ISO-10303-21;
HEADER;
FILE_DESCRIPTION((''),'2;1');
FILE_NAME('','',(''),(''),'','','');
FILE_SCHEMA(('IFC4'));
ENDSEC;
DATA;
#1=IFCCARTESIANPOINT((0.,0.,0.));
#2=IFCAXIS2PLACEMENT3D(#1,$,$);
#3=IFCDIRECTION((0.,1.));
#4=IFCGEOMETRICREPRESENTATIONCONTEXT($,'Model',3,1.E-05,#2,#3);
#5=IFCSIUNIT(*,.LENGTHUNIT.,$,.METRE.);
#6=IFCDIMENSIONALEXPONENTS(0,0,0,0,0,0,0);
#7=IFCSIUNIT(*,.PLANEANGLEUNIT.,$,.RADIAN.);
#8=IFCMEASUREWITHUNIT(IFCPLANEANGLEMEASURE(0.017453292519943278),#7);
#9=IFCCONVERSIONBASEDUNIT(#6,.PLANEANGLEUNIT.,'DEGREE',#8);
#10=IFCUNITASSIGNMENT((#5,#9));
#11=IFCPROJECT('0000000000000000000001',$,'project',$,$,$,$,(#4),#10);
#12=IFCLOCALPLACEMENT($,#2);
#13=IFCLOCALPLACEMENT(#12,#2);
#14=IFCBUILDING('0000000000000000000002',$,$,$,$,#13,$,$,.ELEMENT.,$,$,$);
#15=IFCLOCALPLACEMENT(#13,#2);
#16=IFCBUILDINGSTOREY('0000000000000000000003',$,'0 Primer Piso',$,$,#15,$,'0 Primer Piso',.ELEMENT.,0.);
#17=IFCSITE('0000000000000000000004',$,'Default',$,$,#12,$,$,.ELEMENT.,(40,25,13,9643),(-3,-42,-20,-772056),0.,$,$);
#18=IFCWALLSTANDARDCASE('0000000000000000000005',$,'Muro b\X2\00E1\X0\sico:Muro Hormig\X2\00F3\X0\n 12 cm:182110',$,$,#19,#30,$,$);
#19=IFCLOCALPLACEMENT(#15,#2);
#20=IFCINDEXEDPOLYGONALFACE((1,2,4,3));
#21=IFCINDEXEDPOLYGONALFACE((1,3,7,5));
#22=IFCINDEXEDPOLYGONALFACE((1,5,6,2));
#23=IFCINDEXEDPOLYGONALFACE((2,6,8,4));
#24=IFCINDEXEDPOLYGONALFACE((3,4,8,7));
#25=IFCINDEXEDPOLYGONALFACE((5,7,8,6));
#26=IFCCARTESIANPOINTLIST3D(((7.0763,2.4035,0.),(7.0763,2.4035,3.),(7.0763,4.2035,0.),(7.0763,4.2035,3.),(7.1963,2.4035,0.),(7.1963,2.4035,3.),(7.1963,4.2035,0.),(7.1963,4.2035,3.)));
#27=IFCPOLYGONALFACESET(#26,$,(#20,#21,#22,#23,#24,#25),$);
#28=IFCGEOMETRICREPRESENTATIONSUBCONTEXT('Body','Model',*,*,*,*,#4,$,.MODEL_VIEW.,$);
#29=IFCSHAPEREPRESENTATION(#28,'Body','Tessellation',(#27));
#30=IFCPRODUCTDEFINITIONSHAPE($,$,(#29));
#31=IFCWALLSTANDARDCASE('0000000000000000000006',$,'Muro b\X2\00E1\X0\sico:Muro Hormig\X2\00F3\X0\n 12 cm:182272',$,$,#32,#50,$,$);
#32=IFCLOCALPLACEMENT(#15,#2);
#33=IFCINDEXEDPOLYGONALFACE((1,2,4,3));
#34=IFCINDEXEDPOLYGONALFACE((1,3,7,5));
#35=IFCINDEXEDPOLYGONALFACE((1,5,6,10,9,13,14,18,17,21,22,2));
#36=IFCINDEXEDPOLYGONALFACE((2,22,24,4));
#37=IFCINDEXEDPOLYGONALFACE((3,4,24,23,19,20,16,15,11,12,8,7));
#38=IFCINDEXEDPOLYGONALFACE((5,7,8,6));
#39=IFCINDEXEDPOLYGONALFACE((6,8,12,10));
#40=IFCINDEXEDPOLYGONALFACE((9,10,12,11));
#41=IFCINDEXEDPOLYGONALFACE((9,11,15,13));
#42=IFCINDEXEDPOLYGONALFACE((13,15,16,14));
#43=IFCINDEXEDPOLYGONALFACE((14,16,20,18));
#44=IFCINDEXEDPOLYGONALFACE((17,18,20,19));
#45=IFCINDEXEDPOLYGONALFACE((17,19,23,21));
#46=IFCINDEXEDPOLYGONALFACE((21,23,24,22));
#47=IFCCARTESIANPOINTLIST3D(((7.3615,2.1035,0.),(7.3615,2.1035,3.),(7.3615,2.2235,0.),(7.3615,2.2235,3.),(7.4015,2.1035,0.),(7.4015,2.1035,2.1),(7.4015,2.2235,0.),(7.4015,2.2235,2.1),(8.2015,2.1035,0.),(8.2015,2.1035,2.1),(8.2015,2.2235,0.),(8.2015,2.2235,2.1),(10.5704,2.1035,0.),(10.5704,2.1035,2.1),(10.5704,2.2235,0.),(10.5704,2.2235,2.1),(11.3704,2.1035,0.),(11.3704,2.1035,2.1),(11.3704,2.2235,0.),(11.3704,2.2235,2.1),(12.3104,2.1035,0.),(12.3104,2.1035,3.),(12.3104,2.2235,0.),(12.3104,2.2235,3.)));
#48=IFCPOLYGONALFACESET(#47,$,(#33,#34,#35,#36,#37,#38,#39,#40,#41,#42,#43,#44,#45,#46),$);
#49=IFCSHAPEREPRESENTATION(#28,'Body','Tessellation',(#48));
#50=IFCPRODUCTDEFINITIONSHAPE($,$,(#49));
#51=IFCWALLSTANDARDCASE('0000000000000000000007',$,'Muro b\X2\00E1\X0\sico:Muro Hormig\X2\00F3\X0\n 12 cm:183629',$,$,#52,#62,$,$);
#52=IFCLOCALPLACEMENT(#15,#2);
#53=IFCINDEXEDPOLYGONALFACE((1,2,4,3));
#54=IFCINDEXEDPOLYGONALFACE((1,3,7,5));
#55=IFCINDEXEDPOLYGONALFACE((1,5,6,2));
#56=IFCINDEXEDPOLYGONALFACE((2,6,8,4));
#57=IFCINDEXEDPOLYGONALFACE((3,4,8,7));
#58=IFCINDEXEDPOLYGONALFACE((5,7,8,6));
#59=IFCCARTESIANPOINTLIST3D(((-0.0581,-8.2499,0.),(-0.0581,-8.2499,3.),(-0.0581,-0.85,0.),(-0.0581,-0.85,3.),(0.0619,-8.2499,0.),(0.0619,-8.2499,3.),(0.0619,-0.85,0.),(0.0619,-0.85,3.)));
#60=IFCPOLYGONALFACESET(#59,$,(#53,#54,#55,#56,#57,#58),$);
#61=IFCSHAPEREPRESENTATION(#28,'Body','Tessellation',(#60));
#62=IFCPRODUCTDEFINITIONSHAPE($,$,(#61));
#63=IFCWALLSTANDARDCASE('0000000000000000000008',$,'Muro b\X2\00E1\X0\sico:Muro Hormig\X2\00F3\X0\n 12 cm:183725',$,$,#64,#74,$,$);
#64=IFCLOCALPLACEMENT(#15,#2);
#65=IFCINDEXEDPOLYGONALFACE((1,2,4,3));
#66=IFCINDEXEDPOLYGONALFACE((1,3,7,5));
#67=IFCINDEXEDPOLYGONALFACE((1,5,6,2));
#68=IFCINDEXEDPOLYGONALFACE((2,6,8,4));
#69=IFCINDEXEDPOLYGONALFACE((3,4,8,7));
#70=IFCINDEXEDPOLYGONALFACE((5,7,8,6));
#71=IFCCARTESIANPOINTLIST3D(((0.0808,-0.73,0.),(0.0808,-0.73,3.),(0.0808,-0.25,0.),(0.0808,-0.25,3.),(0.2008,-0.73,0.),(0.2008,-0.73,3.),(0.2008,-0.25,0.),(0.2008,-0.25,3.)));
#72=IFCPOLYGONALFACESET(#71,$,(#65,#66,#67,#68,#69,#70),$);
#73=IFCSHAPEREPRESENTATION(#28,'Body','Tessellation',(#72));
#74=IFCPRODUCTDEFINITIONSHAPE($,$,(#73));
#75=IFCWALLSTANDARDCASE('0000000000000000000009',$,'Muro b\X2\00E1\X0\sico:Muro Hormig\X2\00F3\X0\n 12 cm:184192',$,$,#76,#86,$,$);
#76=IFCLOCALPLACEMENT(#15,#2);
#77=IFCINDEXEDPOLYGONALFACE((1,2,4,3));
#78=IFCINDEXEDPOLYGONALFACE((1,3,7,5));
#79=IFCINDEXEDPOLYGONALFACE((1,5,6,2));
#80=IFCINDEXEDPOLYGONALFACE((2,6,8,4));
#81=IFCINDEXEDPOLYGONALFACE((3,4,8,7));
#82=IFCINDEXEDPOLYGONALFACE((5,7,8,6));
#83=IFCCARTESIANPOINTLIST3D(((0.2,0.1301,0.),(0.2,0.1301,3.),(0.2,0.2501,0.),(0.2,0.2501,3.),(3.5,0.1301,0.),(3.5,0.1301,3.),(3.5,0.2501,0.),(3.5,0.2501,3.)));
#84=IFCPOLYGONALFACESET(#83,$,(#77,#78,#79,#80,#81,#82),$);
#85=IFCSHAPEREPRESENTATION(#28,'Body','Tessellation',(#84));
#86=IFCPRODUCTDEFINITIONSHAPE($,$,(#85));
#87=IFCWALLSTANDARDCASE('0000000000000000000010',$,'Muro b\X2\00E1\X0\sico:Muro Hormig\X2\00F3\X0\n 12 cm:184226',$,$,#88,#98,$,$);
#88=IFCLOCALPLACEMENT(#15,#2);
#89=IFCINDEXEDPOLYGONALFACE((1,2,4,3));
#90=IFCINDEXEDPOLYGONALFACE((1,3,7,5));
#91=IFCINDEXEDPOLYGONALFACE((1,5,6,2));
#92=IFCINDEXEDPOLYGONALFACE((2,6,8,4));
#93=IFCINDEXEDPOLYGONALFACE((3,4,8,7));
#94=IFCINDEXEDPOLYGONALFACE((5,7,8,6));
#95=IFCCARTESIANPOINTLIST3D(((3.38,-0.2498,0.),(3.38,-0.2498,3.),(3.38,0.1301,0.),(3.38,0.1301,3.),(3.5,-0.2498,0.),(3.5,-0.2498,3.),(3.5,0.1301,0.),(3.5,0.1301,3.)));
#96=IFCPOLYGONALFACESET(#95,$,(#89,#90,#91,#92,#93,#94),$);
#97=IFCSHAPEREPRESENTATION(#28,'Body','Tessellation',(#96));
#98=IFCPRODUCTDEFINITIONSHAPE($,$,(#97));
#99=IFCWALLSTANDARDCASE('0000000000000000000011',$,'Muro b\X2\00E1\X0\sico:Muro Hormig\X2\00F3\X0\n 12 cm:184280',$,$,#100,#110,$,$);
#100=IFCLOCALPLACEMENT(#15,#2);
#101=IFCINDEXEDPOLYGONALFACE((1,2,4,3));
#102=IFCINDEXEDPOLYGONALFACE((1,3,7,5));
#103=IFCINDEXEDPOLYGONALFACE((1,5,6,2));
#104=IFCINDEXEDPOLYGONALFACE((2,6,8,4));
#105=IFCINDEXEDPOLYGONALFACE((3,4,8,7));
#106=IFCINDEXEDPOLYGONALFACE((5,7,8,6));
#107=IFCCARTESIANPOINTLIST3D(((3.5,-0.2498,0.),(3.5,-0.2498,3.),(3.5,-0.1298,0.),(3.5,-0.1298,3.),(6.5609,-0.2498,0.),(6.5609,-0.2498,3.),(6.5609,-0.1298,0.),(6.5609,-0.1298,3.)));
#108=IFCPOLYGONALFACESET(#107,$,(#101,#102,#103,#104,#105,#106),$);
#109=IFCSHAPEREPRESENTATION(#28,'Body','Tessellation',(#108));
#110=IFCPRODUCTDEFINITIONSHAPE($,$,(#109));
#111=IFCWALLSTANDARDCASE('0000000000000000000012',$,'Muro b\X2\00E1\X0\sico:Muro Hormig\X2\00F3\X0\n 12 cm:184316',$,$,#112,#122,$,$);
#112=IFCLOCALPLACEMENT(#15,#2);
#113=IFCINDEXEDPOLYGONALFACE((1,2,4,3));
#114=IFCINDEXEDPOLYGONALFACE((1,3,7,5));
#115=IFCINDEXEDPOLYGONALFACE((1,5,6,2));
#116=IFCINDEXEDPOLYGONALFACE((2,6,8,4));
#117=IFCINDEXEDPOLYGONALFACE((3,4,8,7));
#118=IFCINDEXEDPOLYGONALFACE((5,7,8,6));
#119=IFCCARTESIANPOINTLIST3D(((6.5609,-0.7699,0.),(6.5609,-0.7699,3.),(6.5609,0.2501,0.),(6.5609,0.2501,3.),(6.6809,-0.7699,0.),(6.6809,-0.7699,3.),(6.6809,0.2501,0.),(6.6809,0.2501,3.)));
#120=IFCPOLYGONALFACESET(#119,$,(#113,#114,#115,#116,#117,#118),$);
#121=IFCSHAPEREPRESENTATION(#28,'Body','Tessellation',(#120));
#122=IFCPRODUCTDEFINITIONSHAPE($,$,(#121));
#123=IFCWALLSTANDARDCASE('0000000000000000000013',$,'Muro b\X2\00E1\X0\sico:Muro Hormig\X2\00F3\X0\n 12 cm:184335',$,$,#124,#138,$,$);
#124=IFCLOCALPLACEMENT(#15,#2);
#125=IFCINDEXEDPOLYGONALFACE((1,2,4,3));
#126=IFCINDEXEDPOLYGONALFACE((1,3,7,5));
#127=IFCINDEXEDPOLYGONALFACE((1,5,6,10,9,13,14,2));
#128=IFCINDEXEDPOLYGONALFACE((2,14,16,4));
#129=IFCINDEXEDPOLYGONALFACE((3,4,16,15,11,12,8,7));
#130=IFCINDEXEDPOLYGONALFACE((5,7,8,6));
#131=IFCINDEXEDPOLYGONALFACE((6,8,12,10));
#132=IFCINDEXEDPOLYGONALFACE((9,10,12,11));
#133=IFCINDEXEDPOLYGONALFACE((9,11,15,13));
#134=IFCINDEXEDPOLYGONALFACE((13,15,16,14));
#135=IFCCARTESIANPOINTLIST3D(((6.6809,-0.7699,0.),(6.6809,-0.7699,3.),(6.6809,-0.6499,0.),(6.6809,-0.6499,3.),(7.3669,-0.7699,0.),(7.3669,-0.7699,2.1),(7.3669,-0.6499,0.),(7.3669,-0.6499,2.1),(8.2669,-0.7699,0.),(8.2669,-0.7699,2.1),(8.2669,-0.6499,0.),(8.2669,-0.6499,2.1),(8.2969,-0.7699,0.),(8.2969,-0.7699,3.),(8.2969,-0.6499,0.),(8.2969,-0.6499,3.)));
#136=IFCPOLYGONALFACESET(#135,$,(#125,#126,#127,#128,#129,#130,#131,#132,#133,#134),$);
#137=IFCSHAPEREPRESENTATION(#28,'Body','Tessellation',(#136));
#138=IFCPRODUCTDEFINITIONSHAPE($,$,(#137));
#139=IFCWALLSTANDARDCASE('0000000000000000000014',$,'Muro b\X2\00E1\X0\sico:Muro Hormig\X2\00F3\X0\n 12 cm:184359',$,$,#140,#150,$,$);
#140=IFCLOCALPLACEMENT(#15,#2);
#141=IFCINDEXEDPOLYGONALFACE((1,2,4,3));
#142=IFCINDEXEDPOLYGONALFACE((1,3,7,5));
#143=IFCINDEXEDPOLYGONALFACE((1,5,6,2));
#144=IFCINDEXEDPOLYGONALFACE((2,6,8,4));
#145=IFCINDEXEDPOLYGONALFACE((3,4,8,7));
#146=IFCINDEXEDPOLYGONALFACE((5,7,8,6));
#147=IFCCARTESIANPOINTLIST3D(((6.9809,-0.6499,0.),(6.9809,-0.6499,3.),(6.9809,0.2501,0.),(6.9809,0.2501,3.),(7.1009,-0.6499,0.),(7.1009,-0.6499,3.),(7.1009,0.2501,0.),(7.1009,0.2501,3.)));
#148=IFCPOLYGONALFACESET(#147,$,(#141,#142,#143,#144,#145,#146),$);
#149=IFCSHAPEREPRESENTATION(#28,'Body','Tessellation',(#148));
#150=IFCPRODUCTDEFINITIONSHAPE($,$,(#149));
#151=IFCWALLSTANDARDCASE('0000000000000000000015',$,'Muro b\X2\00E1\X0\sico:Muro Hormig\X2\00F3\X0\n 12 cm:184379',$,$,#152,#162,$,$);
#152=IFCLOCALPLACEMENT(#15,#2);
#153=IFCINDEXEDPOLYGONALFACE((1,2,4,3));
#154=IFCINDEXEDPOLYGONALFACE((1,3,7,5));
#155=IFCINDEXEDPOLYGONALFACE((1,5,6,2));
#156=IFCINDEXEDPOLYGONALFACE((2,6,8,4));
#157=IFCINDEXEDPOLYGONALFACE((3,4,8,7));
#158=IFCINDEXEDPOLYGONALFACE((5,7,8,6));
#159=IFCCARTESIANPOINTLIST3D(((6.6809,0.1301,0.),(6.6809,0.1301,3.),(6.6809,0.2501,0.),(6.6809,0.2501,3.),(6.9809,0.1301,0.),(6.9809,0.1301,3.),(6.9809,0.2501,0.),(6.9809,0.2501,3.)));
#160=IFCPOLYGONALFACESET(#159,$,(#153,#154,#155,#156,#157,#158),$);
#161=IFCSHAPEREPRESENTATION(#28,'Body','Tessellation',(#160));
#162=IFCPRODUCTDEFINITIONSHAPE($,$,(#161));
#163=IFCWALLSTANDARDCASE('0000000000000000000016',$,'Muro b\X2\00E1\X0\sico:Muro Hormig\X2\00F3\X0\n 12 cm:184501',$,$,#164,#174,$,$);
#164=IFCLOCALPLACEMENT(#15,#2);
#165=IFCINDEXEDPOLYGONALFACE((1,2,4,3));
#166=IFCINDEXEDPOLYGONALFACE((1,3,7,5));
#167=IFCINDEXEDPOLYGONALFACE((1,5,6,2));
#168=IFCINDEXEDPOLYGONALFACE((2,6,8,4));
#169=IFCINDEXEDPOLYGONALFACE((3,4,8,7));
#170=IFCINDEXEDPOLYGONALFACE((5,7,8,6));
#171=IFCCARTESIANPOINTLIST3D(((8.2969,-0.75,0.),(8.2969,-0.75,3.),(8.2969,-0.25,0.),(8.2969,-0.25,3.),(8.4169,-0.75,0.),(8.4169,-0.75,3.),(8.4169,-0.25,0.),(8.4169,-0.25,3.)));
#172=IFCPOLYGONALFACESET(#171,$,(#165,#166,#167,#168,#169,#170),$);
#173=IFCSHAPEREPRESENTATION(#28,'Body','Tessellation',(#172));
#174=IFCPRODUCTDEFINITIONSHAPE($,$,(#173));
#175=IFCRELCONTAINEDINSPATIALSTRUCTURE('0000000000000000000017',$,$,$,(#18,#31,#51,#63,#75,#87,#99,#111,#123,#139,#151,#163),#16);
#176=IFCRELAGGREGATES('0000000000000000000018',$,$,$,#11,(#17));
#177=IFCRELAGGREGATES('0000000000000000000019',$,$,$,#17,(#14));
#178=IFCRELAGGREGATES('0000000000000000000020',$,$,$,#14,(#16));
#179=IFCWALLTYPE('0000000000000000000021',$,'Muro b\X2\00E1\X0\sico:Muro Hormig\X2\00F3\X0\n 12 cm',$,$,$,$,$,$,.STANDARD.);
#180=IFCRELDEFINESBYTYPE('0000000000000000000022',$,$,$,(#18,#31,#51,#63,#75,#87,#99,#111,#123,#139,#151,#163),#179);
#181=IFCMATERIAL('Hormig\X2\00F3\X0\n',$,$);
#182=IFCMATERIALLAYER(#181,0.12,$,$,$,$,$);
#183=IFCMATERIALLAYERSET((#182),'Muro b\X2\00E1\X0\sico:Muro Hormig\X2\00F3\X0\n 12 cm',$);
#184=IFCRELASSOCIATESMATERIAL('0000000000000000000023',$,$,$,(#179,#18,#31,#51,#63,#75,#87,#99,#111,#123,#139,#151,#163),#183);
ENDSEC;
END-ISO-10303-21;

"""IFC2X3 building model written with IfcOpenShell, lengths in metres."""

from ifc_helpers import new_model, entity, si_unit, converted_unit, direction, frame, frame_2d, origin, place, context, subcontext, project, spatial, rectangle, extrude, material, layer, layer_set, layer_usage, type_object, element, save


model = new_model("IFC2X3")

# Units and contexts
model_context = context("Model", 3, precision=1e-05, world=origin(), true_north=direction((0.0, 1.0)))
body_context = subcontext(model_context, "Body", "Model", "MODEL_VIEW")
ifc_project = project(units=[si_unit("LENGTHUNIT", "METRE"), converted_unit("PLANEANGLEUNIT", "DEGREE", entity("IfcPlaneAngleMeasure", 0.017453292519943278), si_unit("PLANEANGLEUNIT", "RADIAN"), dimensions=[0, 0, 0, 0, 0, 0, 0])], contexts=[model_context])

# Site, building, storey
site_placement = place(None, origin())
site = spatial("IfcSite", under=ifc_project, at=site_placement, Name="Default", CompositionType="ELEMENT", RefLatitude=(40, 25, 13, 9643), RefLongitude=(-3, -42, -20, -772056), RefElevation=0.0)
building_placement = place(site_placement, origin())
building = spatial("IfcBuilding", under=site, at=building_placement, CompositionType="ELEMENT")
storey_placement = place(building_placement, origin())
storey = spatial("IfcBuildingStorey", under=building, at=storey_placement, Name="0 Primer Piso", LongName="0 Primer Piso", CompositionType="ELEMENT", Elevation=0.0)

# Wall
ifc_material = material(Name="Hormigón")
ifc_layer = layer(ifc_material, 0.12)
ifc_layer_set = layer_set([ifc_layer], Name="Muro básico:Muro Hormigón 12 cm")
ifc_layer_usage_1 = layer_usage(ifc_layer_set, "AXIS2", "NEGATIVE", 0.06)
wall_type = type_object("IfcWallType", Name="Muro básico:Muro Hormigón 12 cm", PredefinedType="STANDARD", material=ifc_layer_set)
wall_1_placement = place(storey_placement, frame((7.1363, 2.4035, 0.0), z_axis=(0.0, 0.0, 1.0), x_axis=(0.0, 1.0, 0.0)))
element("IfcWallStandardCase", 1, at=wall_1_placement, inside=storey, type_object=wall_type, material=ifc_layer_usage_1, Name="Muro básico:Muro Hormigón 12 cm:182110", context=body_context, shape_type="SweptSolid", body=[
    extrude(rectangle(XDim=1.8, YDim=0.12, at=frame_2d((0.9, 0.0), x_axis=(-1.0, 0.0))), origin(), (0.0, 0.0, 1.0), 3.0),
])

# Wall, openings
ifc_layer_usage_2 = layer_usage(ifc_layer_set, "AXIS2", "NEGATIVE", 0.06)
wall_2_placement = place(storey_placement, frame((12.3104, 2.1635, 0.0), z_axis=(0.0, 0.0, 1.0), x_axis=(-1.0, 0.0, 0.0)))
wall_2 = element("IfcWallStandardCase", 2, at=wall_2_placement, inside=storey, type_object=wall_type, material=ifc_layer_usage_2, Name="Muro básico:Muro Hormigón 12 cm:182272", context=body_context, shape_type="SweptSolid", body=[
    extrude(rectangle(XDim=4.9489, YDim=0.12, at=frame_2d((2.4744, 0.0), x_axis=(1.0, 0.0))), origin(), (0.0, 0.0, 1.0), 3.0),
])
opening_1_placement = place(wall_2_placement, frame((4.1089, -0.06, 0.0)))
element("IfcOpeningElement", 3, at=opening_1_placement, cuts=wall_2, ObjectType="Opening", context=body_context, shape_type="SweptSolid", body=[
    extrude(rectangle(XDim=2.1, YDim=0.8, at=frame_2d((1.05, 0.4), x_axis=(1.0, 0.0))), frame((0.0, 0.0, 0.0), z_axis=(0.0, 1.0, 0.0), x_axis=(0.0, 0.0, 1.0)), (0.0, 0.0, 1.0), 0.12),
])
opening_2_placement = place(wall_2_placement, frame((0.94, -0.06, 0.0)))
element("IfcOpeningElement", 4, at=opening_2_placement, cuts=wall_2, ObjectType="Opening", context=body_context, shape_type="SweptSolid", body=[
    extrude(rectangle(XDim=2.1, YDim=0.8, at=frame_2d((1.05, 0.4), x_axis=(1.0, 0.0))), frame((0.0, 0.0, 0.0), z_axis=(0.0, 1.0, 0.0), x_axis=(0.0, 0.0, 1.0)), (0.0, 0.0, 1.0), 0.12),
])

# Walls
ifc_layer_usage_3 = layer_usage(ifc_layer_set, "AXIS2", "NEGATIVE", 0.06)
wall_3_placement = place(storey_placement, frame((0.0019, -8.2499, 0.0), z_axis=(0.0, 0.0, 1.0), x_axis=(0.0, 1.0, 0.0)))
element("IfcWallStandardCase", 5, at=wall_3_placement, inside=storey, type_object=wall_type, material=ifc_layer_usage_3, Name="Muro básico:Muro Hormigón 12 cm:183629", context=body_context, shape_type="SweptSolid", body=[
    extrude(rectangle(XDim=7.3999, YDim=0.12, at=frame_2d((3.6999, 0.0), x_axis=(-1.0, 0.0))), origin(), (0.0, 0.0, 1.0), 3.0),
])
ifc_layer_usage_4 = layer_usage(ifc_layer_set, "AXIS2", "NEGATIVE", 0.06)
wall_4_placement = place(storey_placement, frame((0.1408, -0.73, 0.0), z_axis=(0.0, 0.0, 1.0), x_axis=(0.0, 1.0, 0.0)))
element("IfcWallStandardCase", 6, at=wall_4_placement, inside=storey, type_object=wall_type, material=ifc_layer_usage_4, Name="Muro básico:Muro Hormigón 12 cm:183725", context=body_context, shape_type="SweptSolid", body=[
    extrude(rectangle(XDim=0.48, YDim=0.12, at=frame_2d((0.24, 0.0), x_axis=(-1.0, 0.0))), origin(), (0.0, 0.0, 1.0), 3.0),
])
ifc_layer_usage_5 = layer_usage(ifc_layer_set, "AXIS2", "NEGATIVE", 0.06)
wall_5_placement = place(storey_placement, frame((0.2, 0.1901, 0.0)))
element("IfcWallStandardCase", 7, at=wall_5_placement, inside=storey, type_object=wall_type, material=ifc_layer_usage_5, Name="Muro básico:Muro Hormigón 12 cm:184192", context=body_context, shape_type="SweptSolid", body=[
    extrude(rectangle(XDim=3.3, YDim=0.12, at=frame_2d((1.65, 0.0), x_axis=(-1.0, 0.0))), origin(), (0.0, 0.0, 1.0), 3.0),
])
ifc_layer_usage_6 = layer_usage(ifc_layer_set, "AXIS2", "NEGATIVE", 0.06)
wall_6_placement = place(storey_placement, frame((3.44, 0.1301, 0.0), z_axis=(0.0, 0.0, 1.0), x_axis=(0.0, -1.0, 0.0)))
element("IfcWallStandardCase", 8, at=wall_6_placement, inside=storey, type_object=wall_type, material=ifc_layer_usage_6, Name="Muro básico:Muro Hormigón 12 cm:184226", context=body_context, shape_type="SweptSolid", body=[
    extrude(rectangle(XDim=0.3799, YDim=0.12, at=frame_2d((0.1899, 0.0), x_axis=(-1.0, 0.0))), origin(), (0.0, 0.0, 1.0), 3.0),
])
ifc_layer_usage_7 = layer_usage(ifc_layer_set, "AXIS2", "NEGATIVE", 0.06)
wall_7_placement = place(storey_placement, frame((3.5, -0.1898, 0.0)))
element("IfcWallStandardCase", 9, at=wall_7_placement, inside=storey, type_object=wall_type, material=ifc_layer_usage_7, Name="Muro básico:Muro Hormigón 12 cm:184280", context=body_context, shape_type="SweptSolid", body=[
    extrude(rectangle(XDim=3.0609, YDim=0.12, at=frame_2d((1.5304, 0.0), x_axis=(-1.0, 0.0))), origin(), (0.0, 0.0, 1.0), 3.0),
])
ifc_layer_usage_8 = layer_usage(ifc_layer_set, "AXIS2", "NEGATIVE", 0.06)
wall_8_placement = place(storey_placement, frame((6.6209, 0.2501, 0.0), z_axis=(0.0, 0.0, 1.0), x_axis=(0.0, -1.0, 0.0)))
element("IfcWallStandardCase", 10, at=wall_8_placement, inside=storey, type_object=wall_type, material=ifc_layer_usage_8, Name="Muro básico:Muro Hormigón 12 cm:184316", context=body_context, shape_type="SweptSolid", body=[
    extrude(rectangle(XDim=1.02, YDim=0.12, at=frame_2d((0.51, 0.0), x_axis=(-1.0, 0.0))), origin(), (0.0, 0.0, 1.0), 3.0),
])

# Wall, opening
ifc_layer_usage_9 = layer_usage(ifc_layer_set, "AXIS2", "NEGATIVE", 0.06)
wall_9_placement = place(storey_placement, frame((6.6809, -0.7099, 0.0)))
wall_9 = element("IfcWallStandardCase", 11, at=wall_9_placement, inside=storey, type_object=wall_type, material=ifc_layer_usage_9, Name="Muro básico:Muro Hormigón 12 cm:184335", context=body_context, shape_type="SweptSolid", body=[
    extrude(rectangle(XDim=1.616, YDim=0.12, at=frame_2d((0.808, 0.0), x_axis=(1.0, 0.0))), origin(), (0.0, 0.0, 1.0), 3.0),
])
opening_3_placement = place(wall_9_placement, frame((0.686, -0.06, 0.0)))
element("IfcOpeningElement", 12, at=opening_3_placement, cuts=wall_9, ObjectType="Opening", context=body_context, shape_type="SweptSolid", body=[
    extrude(rectangle(XDim=2.1, YDim=0.9, at=frame_2d((1.05, 0.45), x_axis=(1.0, 0.0))), frame((0.0, 0.0, 0.0), z_axis=(0.0, 1.0, 0.0), x_axis=(0.0, 0.0, 1.0)), (0.0, 0.0, 1.0), 0.12),
])

# Walls
ifc_layer_usage_10 = layer_usage(ifc_layer_set, "AXIS2", "NEGATIVE", 0.06)
wall_10_placement = place(storey_placement, frame((7.0409, -0.6499, 0.0), z_axis=(0.0, 0.0, 1.0), x_axis=(0.0, 1.0, 0.0)))
element("IfcWallStandardCase", 13, at=wall_10_placement, inside=storey, type_object=wall_type, material=ifc_layer_usage_10, Name="Muro básico:Muro Hormigón 12 cm:184359", context=body_context, shape_type="SweptSolid", body=[
    extrude(rectangle(XDim=0.9, YDim=0.12, at=frame_2d((0.45, 0.0), x_axis=(-1.0, 0.0))), origin(), (0.0, 0.0, 1.0), 3.0),
])
ifc_layer_usage_11 = layer_usage(ifc_layer_set, "AXIS2", "NEGATIVE", 0.06)
wall_11_placement = place(storey_placement, frame((6.9809, 0.1901, 0.0), z_axis=(0.0, 0.0, 1.0), x_axis=(-1.0, 0.0, 0.0)))
element("IfcWallStandardCase", 14, at=wall_11_placement, inside=storey, type_object=wall_type, material=ifc_layer_usage_11, Name="Muro básico:Muro Hormigón 12 cm:184379", context=body_context, shape_type="SweptSolid", body=[
    extrude(rectangle(XDim=0.3001, YDim=0.12, at=frame_2d((0.15, 0.0), x_axis=(-1.0, 0.0))), origin(), (0.0, 0.0, 1.0), 3.0),
])
ifc_layer_usage_12 = layer_usage(ifc_layer_set, "AXIS2", "NEGATIVE", 0.06)
wall_12_placement = place(storey_placement, frame((8.3569, -0.25, 0.0), z_axis=(0.0, 0.0, 1.0), x_axis=(0.0, -1.0, 0.0)))
element("IfcWallStandardCase", 15, at=wall_12_placement, inside=storey, type_object=wall_type, material=ifc_layer_usage_12, Name="Muro básico:Muro Hormigón 12 cm:184501", context=body_context, shape_type="SweptSolid", body=[
    extrude(rectangle(XDim=0.5, YDim=0.12, at=frame_2d((0.25, 0.0), x_axis=(-1.0, 0.0))), origin(), (0.0, 0.0, 1.0), 3.0),
])

save(model, "model.ifc")
